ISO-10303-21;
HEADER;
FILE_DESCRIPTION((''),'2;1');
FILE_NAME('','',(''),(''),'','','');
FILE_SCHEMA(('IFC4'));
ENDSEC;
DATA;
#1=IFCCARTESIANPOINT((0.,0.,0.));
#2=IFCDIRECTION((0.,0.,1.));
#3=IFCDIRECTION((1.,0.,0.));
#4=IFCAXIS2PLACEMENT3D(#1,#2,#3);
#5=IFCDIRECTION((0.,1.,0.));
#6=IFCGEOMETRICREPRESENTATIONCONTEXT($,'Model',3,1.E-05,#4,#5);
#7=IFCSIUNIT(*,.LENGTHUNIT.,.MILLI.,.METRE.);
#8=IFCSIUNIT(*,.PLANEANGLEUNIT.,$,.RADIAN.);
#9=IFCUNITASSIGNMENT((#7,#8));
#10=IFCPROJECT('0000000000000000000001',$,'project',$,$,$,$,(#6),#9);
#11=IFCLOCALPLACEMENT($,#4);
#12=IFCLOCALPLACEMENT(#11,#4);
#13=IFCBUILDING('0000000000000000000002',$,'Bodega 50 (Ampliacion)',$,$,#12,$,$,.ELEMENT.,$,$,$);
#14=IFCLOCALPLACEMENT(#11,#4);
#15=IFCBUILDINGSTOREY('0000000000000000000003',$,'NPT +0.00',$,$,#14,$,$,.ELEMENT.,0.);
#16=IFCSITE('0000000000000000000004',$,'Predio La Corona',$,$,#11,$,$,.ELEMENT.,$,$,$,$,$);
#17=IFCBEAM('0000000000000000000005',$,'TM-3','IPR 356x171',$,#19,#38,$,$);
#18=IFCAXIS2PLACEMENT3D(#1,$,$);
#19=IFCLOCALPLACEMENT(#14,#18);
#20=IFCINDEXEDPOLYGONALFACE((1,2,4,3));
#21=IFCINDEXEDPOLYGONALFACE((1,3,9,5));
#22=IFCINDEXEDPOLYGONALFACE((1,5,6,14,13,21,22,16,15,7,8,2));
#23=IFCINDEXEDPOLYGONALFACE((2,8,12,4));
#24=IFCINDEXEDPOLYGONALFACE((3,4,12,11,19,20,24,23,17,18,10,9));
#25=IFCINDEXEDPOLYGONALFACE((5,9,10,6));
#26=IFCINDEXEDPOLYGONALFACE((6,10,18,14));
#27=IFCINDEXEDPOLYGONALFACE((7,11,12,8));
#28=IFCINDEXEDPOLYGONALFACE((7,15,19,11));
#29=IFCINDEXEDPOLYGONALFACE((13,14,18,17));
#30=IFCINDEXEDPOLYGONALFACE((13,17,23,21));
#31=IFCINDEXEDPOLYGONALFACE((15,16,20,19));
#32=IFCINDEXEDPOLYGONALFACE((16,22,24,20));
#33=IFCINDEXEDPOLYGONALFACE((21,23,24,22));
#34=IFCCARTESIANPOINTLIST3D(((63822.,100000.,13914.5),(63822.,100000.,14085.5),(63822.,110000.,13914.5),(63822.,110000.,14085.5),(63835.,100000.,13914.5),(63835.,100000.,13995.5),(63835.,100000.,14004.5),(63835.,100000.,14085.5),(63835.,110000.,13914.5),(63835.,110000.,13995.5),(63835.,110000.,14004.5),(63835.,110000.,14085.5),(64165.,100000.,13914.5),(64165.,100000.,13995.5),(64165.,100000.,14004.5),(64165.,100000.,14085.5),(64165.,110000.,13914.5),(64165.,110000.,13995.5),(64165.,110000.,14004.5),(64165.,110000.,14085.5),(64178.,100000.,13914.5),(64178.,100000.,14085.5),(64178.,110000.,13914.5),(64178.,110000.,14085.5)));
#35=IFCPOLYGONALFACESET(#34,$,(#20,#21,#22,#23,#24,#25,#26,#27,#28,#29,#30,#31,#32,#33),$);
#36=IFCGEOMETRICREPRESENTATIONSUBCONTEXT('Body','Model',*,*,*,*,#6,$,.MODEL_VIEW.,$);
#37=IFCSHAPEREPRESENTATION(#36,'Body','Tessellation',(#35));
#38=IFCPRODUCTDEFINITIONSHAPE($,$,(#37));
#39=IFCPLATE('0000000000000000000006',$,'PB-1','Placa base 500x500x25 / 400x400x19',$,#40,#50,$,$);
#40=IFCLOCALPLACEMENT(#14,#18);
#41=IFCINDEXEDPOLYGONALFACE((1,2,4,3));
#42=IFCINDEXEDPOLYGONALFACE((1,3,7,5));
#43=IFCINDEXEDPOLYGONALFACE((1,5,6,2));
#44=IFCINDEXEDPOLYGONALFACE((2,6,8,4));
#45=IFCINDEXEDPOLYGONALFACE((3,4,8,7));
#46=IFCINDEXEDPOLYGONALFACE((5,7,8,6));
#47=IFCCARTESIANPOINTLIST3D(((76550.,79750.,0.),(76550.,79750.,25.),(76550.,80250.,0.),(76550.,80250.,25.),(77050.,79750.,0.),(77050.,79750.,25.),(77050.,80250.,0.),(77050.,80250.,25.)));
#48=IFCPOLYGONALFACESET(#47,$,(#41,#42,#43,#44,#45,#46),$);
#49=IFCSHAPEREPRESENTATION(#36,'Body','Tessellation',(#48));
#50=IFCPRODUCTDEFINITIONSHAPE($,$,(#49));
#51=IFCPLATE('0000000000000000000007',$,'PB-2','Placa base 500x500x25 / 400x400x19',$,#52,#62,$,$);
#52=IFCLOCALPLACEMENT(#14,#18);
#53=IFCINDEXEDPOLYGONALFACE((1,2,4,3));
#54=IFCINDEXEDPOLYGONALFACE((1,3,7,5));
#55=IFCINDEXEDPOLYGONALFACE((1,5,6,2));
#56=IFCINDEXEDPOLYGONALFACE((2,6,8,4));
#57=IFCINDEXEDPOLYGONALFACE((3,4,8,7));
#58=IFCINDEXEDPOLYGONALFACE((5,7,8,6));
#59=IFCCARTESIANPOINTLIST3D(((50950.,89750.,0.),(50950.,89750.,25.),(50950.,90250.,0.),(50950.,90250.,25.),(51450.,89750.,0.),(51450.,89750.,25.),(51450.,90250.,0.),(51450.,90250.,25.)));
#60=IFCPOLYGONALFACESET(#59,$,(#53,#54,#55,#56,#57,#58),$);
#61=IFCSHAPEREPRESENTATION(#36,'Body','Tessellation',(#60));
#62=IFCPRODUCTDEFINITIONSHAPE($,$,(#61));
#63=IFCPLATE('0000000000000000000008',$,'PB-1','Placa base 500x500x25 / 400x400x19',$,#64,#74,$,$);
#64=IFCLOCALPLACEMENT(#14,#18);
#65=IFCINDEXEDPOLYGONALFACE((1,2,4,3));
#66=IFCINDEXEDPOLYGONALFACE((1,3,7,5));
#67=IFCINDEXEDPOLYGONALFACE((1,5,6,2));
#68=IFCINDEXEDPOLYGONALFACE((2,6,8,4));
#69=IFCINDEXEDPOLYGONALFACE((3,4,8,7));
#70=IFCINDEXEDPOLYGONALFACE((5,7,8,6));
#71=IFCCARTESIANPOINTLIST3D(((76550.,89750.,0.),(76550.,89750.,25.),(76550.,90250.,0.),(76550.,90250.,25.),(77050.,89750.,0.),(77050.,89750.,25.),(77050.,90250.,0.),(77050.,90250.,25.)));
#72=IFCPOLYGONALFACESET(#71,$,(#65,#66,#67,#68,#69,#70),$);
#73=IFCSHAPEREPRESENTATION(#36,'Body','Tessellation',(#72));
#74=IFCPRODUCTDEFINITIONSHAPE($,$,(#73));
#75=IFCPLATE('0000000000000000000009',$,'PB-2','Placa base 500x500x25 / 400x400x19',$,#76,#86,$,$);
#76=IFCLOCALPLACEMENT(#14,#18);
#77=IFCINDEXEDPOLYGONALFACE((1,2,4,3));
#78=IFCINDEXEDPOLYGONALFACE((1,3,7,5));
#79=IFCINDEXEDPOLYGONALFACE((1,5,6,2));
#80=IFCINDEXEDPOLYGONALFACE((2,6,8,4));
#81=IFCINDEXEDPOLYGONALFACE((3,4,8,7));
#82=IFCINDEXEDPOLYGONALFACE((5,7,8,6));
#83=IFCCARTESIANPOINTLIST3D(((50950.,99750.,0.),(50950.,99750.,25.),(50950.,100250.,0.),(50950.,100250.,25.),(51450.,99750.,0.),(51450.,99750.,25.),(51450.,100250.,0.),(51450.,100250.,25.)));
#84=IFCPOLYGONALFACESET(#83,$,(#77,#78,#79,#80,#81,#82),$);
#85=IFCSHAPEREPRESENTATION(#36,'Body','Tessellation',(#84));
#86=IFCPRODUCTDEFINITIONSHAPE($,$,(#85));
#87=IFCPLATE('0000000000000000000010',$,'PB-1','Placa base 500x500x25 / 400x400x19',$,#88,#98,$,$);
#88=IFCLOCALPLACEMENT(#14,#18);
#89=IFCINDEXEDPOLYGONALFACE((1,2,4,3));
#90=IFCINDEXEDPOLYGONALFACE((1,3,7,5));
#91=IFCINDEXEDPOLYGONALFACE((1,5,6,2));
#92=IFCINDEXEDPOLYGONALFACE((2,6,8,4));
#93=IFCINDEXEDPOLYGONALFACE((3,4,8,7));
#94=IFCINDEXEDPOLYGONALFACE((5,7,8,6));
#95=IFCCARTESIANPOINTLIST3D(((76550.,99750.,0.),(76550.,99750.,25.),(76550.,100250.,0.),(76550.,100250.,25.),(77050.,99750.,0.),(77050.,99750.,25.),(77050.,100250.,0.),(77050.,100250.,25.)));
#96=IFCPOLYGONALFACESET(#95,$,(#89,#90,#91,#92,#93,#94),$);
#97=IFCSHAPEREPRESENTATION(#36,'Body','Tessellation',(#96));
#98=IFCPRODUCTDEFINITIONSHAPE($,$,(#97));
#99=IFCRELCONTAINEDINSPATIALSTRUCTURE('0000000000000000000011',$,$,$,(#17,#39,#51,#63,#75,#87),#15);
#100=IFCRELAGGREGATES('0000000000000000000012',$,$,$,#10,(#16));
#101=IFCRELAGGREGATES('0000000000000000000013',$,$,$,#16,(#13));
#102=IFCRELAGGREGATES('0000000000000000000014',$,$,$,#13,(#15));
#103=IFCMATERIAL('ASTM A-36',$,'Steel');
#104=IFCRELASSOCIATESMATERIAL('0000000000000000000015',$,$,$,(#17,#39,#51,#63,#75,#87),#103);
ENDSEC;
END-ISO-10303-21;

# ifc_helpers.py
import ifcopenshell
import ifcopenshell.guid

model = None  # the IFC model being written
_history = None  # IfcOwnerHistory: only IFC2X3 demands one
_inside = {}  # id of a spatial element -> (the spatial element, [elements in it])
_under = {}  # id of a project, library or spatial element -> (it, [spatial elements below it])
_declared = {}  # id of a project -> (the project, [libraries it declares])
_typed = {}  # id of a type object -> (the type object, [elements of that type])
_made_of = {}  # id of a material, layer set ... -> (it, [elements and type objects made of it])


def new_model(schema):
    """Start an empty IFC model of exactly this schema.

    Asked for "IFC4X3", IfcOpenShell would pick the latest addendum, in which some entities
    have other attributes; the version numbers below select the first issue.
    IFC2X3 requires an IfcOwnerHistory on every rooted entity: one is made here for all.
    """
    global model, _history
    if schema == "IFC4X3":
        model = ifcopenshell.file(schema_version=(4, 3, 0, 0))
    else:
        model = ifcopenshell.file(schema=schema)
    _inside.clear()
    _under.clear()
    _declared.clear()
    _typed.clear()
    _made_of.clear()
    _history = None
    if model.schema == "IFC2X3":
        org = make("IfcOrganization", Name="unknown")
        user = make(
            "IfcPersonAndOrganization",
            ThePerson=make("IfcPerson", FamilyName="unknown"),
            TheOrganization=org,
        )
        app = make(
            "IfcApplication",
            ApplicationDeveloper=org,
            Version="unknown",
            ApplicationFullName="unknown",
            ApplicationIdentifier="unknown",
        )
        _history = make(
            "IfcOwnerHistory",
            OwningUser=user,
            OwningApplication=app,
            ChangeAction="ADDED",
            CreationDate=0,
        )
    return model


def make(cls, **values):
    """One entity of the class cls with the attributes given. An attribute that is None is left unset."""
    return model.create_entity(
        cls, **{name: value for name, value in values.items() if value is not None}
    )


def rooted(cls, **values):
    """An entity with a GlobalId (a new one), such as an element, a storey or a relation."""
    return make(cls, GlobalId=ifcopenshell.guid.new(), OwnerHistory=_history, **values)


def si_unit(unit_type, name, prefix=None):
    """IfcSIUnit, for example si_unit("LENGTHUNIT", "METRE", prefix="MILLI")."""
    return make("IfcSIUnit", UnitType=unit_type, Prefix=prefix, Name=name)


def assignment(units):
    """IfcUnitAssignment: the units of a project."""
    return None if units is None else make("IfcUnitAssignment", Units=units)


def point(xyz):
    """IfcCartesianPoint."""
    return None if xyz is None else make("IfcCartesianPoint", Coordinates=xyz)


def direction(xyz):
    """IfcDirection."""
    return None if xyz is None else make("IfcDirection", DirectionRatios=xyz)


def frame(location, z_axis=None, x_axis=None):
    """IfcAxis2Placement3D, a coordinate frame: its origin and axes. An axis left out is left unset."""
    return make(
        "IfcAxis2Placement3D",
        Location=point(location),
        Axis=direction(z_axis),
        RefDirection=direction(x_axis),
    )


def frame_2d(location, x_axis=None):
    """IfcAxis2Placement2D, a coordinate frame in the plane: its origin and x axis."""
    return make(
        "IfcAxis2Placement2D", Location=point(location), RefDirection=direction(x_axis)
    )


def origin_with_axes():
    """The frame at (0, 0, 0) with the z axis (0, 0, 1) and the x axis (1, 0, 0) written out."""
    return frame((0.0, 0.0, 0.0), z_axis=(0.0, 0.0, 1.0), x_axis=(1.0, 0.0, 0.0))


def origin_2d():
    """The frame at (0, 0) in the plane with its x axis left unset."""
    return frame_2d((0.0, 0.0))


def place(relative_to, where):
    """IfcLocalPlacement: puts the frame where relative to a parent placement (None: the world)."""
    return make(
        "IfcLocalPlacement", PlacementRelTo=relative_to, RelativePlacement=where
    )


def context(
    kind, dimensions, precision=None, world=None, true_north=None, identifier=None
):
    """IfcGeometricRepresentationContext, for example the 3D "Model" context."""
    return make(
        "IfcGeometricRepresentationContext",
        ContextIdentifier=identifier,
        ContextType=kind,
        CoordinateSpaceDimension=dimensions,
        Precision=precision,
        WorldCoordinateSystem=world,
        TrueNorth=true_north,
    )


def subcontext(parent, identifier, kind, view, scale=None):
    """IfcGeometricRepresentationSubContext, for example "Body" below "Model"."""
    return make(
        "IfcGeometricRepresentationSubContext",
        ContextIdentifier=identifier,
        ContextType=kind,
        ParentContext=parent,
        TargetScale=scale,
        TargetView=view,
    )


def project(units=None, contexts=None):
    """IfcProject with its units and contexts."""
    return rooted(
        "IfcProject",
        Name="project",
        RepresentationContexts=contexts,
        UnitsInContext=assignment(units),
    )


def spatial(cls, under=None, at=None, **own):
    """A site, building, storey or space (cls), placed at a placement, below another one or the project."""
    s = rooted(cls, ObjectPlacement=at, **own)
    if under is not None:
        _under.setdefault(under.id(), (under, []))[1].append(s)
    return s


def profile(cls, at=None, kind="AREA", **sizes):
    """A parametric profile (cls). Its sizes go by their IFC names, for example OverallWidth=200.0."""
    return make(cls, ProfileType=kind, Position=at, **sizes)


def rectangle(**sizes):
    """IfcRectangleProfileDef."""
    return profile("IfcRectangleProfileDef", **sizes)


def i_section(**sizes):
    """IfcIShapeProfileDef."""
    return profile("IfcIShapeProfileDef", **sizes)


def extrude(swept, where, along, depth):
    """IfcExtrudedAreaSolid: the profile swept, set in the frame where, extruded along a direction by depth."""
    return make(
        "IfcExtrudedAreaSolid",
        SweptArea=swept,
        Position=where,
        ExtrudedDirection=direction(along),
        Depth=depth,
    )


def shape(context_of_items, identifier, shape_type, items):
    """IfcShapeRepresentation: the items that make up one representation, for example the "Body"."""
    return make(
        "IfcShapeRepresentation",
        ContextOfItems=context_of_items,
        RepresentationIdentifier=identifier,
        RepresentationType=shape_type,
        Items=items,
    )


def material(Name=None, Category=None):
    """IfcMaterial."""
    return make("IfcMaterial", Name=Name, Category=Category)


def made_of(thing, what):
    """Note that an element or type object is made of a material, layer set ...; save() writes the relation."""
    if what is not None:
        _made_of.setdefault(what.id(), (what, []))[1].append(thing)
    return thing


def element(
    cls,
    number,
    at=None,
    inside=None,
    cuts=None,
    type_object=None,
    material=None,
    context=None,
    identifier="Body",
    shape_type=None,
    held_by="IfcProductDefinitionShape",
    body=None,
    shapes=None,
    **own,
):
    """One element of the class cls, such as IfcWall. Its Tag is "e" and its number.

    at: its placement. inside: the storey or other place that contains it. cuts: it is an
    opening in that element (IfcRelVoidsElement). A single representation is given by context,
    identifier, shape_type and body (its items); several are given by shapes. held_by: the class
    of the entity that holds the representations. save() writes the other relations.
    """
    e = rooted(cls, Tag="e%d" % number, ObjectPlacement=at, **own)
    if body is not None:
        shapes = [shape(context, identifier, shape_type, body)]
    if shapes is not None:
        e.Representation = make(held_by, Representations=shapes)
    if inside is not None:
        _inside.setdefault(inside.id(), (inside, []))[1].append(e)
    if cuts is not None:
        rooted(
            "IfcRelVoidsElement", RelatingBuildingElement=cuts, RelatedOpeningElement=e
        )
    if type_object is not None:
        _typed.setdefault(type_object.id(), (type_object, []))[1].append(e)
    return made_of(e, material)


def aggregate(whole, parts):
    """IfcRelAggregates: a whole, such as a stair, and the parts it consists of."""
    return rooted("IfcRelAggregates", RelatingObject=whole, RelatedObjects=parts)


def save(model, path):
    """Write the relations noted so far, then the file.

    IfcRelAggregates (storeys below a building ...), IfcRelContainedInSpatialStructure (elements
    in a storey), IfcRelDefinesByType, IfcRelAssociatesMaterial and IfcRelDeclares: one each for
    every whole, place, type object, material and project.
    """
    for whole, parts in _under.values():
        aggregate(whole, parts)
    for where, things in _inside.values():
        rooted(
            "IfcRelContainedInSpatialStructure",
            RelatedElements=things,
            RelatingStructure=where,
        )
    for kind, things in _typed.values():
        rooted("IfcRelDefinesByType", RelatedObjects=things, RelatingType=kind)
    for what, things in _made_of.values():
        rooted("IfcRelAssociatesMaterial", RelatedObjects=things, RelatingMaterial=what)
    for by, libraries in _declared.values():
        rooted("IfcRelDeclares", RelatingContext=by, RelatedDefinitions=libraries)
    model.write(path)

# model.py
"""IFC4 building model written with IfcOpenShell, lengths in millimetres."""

from ifc_helpers import new_model, si_unit, direction, frame, origin_with_axes, origin_2d, place, context, subcontext, project, spatial, rectangle, i_section, extrude, material, element, save


model = new_model("IFC4")

# Units and contexts
model_context = context("Model", 3, precision=1e-05, world=origin_with_axes(), true_north=direction((0.0, 1.0, 0.0)))
body_context = subcontext(model_context, "Body", "Model", "MODEL_VIEW")
ifc_project = project(units=[si_unit("LENGTHUNIT", "METRE", prefix="MILLI"), si_unit("PLANEANGLEUNIT", "RADIAN")], contexts=[model_context])

# Site, building, storey
site_placement = place(None, origin_with_axes())
site = spatial("IfcSite", under=ifc_project, at=site_placement, Name="Predio La Corona", CompositionType="ELEMENT")
building_placement = place(site_placement, origin_with_axes())
building = spatial("IfcBuilding", under=site, at=building_placement, Name="Bodega 50 (Ampliacion)", CompositionType="ELEMENT")
storey_placement = place(site_placement, origin_with_axes())
storey = spatial("IfcBuildingStorey", under=building, at=storey_placement, Name="NPT +0.00", CompositionType="ELEMENT", Elevation=0.0)

# Shared definitions
ifc_material = material(Name="ASTM A-36", Category="Steel")

# Beam
for number, where, z_axis, x_axis, name in (
    (1, (64000.0, 100000.0, 14000.0), (0.0, 1.0, 0.0), (0.0, 0.0, 1.0), "TM-3"),
):
    element("IfcBeam", number, at=place(storey_placement, frame(where, z_axis=z_axis, x_axis=x_axis)), inside=storey, material=ifc_material, Name=name, Description="IPR 356x171", context=body_context, shape_type="SweptSolid", body=[
        extrude(i_section(OverallWidth=171.0, OverallDepth=356.0, WebThickness=9.0, FlangeThickness=13.0, at=origin_2d()), origin_with_axes(), (0.0, 0.0, 1.0), 10000.0),
    ])

# Plates
for number, where, z_axis, x_axis, name in (
    (2, (76800.0, 80000.0, 0.0), (0.0, 0.0, 1.0), (1.0, 0.0, 0.0), "PB-1"),
    (3, (51200.0, 90000.0, 0.0), (0.0, 0.0, 1.0), (1.0, 0.0, 0.0), "PB-2"),
    (4, (76800.0, 90000.0, 0.0), (0.0, 0.0, 1.0), (1.0, 0.0, 0.0), "PB-1"),
    (5, (51200.0, 100000.0, 0.0), (0.0, 0.0, 1.0), (1.0, 0.0, 0.0), "PB-2"),
    (6, (76800.0, 100000.0, 0.0), (0.0, 0.0, 1.0), (1.0, 0.0, 0.0), "PB-1"),
):
    element("IfcPlate", number, at=place(storey_placement, frame(where, z_axis=z_axis, x_axis=x_axis)), inside=storey, material=ifc_material, Name=name, Description="Placa base 500x500x25 / 400x400x19", context=body_context, shape_type="SweptSolid", body=[
        extrude(rectangle(XDim=500.0, YDim=500.0, at=origin_2d()), origin_with_axes(), (0.0, 0.0, 1.0), 25.0),
    ])

save(model, "model.ifc")
